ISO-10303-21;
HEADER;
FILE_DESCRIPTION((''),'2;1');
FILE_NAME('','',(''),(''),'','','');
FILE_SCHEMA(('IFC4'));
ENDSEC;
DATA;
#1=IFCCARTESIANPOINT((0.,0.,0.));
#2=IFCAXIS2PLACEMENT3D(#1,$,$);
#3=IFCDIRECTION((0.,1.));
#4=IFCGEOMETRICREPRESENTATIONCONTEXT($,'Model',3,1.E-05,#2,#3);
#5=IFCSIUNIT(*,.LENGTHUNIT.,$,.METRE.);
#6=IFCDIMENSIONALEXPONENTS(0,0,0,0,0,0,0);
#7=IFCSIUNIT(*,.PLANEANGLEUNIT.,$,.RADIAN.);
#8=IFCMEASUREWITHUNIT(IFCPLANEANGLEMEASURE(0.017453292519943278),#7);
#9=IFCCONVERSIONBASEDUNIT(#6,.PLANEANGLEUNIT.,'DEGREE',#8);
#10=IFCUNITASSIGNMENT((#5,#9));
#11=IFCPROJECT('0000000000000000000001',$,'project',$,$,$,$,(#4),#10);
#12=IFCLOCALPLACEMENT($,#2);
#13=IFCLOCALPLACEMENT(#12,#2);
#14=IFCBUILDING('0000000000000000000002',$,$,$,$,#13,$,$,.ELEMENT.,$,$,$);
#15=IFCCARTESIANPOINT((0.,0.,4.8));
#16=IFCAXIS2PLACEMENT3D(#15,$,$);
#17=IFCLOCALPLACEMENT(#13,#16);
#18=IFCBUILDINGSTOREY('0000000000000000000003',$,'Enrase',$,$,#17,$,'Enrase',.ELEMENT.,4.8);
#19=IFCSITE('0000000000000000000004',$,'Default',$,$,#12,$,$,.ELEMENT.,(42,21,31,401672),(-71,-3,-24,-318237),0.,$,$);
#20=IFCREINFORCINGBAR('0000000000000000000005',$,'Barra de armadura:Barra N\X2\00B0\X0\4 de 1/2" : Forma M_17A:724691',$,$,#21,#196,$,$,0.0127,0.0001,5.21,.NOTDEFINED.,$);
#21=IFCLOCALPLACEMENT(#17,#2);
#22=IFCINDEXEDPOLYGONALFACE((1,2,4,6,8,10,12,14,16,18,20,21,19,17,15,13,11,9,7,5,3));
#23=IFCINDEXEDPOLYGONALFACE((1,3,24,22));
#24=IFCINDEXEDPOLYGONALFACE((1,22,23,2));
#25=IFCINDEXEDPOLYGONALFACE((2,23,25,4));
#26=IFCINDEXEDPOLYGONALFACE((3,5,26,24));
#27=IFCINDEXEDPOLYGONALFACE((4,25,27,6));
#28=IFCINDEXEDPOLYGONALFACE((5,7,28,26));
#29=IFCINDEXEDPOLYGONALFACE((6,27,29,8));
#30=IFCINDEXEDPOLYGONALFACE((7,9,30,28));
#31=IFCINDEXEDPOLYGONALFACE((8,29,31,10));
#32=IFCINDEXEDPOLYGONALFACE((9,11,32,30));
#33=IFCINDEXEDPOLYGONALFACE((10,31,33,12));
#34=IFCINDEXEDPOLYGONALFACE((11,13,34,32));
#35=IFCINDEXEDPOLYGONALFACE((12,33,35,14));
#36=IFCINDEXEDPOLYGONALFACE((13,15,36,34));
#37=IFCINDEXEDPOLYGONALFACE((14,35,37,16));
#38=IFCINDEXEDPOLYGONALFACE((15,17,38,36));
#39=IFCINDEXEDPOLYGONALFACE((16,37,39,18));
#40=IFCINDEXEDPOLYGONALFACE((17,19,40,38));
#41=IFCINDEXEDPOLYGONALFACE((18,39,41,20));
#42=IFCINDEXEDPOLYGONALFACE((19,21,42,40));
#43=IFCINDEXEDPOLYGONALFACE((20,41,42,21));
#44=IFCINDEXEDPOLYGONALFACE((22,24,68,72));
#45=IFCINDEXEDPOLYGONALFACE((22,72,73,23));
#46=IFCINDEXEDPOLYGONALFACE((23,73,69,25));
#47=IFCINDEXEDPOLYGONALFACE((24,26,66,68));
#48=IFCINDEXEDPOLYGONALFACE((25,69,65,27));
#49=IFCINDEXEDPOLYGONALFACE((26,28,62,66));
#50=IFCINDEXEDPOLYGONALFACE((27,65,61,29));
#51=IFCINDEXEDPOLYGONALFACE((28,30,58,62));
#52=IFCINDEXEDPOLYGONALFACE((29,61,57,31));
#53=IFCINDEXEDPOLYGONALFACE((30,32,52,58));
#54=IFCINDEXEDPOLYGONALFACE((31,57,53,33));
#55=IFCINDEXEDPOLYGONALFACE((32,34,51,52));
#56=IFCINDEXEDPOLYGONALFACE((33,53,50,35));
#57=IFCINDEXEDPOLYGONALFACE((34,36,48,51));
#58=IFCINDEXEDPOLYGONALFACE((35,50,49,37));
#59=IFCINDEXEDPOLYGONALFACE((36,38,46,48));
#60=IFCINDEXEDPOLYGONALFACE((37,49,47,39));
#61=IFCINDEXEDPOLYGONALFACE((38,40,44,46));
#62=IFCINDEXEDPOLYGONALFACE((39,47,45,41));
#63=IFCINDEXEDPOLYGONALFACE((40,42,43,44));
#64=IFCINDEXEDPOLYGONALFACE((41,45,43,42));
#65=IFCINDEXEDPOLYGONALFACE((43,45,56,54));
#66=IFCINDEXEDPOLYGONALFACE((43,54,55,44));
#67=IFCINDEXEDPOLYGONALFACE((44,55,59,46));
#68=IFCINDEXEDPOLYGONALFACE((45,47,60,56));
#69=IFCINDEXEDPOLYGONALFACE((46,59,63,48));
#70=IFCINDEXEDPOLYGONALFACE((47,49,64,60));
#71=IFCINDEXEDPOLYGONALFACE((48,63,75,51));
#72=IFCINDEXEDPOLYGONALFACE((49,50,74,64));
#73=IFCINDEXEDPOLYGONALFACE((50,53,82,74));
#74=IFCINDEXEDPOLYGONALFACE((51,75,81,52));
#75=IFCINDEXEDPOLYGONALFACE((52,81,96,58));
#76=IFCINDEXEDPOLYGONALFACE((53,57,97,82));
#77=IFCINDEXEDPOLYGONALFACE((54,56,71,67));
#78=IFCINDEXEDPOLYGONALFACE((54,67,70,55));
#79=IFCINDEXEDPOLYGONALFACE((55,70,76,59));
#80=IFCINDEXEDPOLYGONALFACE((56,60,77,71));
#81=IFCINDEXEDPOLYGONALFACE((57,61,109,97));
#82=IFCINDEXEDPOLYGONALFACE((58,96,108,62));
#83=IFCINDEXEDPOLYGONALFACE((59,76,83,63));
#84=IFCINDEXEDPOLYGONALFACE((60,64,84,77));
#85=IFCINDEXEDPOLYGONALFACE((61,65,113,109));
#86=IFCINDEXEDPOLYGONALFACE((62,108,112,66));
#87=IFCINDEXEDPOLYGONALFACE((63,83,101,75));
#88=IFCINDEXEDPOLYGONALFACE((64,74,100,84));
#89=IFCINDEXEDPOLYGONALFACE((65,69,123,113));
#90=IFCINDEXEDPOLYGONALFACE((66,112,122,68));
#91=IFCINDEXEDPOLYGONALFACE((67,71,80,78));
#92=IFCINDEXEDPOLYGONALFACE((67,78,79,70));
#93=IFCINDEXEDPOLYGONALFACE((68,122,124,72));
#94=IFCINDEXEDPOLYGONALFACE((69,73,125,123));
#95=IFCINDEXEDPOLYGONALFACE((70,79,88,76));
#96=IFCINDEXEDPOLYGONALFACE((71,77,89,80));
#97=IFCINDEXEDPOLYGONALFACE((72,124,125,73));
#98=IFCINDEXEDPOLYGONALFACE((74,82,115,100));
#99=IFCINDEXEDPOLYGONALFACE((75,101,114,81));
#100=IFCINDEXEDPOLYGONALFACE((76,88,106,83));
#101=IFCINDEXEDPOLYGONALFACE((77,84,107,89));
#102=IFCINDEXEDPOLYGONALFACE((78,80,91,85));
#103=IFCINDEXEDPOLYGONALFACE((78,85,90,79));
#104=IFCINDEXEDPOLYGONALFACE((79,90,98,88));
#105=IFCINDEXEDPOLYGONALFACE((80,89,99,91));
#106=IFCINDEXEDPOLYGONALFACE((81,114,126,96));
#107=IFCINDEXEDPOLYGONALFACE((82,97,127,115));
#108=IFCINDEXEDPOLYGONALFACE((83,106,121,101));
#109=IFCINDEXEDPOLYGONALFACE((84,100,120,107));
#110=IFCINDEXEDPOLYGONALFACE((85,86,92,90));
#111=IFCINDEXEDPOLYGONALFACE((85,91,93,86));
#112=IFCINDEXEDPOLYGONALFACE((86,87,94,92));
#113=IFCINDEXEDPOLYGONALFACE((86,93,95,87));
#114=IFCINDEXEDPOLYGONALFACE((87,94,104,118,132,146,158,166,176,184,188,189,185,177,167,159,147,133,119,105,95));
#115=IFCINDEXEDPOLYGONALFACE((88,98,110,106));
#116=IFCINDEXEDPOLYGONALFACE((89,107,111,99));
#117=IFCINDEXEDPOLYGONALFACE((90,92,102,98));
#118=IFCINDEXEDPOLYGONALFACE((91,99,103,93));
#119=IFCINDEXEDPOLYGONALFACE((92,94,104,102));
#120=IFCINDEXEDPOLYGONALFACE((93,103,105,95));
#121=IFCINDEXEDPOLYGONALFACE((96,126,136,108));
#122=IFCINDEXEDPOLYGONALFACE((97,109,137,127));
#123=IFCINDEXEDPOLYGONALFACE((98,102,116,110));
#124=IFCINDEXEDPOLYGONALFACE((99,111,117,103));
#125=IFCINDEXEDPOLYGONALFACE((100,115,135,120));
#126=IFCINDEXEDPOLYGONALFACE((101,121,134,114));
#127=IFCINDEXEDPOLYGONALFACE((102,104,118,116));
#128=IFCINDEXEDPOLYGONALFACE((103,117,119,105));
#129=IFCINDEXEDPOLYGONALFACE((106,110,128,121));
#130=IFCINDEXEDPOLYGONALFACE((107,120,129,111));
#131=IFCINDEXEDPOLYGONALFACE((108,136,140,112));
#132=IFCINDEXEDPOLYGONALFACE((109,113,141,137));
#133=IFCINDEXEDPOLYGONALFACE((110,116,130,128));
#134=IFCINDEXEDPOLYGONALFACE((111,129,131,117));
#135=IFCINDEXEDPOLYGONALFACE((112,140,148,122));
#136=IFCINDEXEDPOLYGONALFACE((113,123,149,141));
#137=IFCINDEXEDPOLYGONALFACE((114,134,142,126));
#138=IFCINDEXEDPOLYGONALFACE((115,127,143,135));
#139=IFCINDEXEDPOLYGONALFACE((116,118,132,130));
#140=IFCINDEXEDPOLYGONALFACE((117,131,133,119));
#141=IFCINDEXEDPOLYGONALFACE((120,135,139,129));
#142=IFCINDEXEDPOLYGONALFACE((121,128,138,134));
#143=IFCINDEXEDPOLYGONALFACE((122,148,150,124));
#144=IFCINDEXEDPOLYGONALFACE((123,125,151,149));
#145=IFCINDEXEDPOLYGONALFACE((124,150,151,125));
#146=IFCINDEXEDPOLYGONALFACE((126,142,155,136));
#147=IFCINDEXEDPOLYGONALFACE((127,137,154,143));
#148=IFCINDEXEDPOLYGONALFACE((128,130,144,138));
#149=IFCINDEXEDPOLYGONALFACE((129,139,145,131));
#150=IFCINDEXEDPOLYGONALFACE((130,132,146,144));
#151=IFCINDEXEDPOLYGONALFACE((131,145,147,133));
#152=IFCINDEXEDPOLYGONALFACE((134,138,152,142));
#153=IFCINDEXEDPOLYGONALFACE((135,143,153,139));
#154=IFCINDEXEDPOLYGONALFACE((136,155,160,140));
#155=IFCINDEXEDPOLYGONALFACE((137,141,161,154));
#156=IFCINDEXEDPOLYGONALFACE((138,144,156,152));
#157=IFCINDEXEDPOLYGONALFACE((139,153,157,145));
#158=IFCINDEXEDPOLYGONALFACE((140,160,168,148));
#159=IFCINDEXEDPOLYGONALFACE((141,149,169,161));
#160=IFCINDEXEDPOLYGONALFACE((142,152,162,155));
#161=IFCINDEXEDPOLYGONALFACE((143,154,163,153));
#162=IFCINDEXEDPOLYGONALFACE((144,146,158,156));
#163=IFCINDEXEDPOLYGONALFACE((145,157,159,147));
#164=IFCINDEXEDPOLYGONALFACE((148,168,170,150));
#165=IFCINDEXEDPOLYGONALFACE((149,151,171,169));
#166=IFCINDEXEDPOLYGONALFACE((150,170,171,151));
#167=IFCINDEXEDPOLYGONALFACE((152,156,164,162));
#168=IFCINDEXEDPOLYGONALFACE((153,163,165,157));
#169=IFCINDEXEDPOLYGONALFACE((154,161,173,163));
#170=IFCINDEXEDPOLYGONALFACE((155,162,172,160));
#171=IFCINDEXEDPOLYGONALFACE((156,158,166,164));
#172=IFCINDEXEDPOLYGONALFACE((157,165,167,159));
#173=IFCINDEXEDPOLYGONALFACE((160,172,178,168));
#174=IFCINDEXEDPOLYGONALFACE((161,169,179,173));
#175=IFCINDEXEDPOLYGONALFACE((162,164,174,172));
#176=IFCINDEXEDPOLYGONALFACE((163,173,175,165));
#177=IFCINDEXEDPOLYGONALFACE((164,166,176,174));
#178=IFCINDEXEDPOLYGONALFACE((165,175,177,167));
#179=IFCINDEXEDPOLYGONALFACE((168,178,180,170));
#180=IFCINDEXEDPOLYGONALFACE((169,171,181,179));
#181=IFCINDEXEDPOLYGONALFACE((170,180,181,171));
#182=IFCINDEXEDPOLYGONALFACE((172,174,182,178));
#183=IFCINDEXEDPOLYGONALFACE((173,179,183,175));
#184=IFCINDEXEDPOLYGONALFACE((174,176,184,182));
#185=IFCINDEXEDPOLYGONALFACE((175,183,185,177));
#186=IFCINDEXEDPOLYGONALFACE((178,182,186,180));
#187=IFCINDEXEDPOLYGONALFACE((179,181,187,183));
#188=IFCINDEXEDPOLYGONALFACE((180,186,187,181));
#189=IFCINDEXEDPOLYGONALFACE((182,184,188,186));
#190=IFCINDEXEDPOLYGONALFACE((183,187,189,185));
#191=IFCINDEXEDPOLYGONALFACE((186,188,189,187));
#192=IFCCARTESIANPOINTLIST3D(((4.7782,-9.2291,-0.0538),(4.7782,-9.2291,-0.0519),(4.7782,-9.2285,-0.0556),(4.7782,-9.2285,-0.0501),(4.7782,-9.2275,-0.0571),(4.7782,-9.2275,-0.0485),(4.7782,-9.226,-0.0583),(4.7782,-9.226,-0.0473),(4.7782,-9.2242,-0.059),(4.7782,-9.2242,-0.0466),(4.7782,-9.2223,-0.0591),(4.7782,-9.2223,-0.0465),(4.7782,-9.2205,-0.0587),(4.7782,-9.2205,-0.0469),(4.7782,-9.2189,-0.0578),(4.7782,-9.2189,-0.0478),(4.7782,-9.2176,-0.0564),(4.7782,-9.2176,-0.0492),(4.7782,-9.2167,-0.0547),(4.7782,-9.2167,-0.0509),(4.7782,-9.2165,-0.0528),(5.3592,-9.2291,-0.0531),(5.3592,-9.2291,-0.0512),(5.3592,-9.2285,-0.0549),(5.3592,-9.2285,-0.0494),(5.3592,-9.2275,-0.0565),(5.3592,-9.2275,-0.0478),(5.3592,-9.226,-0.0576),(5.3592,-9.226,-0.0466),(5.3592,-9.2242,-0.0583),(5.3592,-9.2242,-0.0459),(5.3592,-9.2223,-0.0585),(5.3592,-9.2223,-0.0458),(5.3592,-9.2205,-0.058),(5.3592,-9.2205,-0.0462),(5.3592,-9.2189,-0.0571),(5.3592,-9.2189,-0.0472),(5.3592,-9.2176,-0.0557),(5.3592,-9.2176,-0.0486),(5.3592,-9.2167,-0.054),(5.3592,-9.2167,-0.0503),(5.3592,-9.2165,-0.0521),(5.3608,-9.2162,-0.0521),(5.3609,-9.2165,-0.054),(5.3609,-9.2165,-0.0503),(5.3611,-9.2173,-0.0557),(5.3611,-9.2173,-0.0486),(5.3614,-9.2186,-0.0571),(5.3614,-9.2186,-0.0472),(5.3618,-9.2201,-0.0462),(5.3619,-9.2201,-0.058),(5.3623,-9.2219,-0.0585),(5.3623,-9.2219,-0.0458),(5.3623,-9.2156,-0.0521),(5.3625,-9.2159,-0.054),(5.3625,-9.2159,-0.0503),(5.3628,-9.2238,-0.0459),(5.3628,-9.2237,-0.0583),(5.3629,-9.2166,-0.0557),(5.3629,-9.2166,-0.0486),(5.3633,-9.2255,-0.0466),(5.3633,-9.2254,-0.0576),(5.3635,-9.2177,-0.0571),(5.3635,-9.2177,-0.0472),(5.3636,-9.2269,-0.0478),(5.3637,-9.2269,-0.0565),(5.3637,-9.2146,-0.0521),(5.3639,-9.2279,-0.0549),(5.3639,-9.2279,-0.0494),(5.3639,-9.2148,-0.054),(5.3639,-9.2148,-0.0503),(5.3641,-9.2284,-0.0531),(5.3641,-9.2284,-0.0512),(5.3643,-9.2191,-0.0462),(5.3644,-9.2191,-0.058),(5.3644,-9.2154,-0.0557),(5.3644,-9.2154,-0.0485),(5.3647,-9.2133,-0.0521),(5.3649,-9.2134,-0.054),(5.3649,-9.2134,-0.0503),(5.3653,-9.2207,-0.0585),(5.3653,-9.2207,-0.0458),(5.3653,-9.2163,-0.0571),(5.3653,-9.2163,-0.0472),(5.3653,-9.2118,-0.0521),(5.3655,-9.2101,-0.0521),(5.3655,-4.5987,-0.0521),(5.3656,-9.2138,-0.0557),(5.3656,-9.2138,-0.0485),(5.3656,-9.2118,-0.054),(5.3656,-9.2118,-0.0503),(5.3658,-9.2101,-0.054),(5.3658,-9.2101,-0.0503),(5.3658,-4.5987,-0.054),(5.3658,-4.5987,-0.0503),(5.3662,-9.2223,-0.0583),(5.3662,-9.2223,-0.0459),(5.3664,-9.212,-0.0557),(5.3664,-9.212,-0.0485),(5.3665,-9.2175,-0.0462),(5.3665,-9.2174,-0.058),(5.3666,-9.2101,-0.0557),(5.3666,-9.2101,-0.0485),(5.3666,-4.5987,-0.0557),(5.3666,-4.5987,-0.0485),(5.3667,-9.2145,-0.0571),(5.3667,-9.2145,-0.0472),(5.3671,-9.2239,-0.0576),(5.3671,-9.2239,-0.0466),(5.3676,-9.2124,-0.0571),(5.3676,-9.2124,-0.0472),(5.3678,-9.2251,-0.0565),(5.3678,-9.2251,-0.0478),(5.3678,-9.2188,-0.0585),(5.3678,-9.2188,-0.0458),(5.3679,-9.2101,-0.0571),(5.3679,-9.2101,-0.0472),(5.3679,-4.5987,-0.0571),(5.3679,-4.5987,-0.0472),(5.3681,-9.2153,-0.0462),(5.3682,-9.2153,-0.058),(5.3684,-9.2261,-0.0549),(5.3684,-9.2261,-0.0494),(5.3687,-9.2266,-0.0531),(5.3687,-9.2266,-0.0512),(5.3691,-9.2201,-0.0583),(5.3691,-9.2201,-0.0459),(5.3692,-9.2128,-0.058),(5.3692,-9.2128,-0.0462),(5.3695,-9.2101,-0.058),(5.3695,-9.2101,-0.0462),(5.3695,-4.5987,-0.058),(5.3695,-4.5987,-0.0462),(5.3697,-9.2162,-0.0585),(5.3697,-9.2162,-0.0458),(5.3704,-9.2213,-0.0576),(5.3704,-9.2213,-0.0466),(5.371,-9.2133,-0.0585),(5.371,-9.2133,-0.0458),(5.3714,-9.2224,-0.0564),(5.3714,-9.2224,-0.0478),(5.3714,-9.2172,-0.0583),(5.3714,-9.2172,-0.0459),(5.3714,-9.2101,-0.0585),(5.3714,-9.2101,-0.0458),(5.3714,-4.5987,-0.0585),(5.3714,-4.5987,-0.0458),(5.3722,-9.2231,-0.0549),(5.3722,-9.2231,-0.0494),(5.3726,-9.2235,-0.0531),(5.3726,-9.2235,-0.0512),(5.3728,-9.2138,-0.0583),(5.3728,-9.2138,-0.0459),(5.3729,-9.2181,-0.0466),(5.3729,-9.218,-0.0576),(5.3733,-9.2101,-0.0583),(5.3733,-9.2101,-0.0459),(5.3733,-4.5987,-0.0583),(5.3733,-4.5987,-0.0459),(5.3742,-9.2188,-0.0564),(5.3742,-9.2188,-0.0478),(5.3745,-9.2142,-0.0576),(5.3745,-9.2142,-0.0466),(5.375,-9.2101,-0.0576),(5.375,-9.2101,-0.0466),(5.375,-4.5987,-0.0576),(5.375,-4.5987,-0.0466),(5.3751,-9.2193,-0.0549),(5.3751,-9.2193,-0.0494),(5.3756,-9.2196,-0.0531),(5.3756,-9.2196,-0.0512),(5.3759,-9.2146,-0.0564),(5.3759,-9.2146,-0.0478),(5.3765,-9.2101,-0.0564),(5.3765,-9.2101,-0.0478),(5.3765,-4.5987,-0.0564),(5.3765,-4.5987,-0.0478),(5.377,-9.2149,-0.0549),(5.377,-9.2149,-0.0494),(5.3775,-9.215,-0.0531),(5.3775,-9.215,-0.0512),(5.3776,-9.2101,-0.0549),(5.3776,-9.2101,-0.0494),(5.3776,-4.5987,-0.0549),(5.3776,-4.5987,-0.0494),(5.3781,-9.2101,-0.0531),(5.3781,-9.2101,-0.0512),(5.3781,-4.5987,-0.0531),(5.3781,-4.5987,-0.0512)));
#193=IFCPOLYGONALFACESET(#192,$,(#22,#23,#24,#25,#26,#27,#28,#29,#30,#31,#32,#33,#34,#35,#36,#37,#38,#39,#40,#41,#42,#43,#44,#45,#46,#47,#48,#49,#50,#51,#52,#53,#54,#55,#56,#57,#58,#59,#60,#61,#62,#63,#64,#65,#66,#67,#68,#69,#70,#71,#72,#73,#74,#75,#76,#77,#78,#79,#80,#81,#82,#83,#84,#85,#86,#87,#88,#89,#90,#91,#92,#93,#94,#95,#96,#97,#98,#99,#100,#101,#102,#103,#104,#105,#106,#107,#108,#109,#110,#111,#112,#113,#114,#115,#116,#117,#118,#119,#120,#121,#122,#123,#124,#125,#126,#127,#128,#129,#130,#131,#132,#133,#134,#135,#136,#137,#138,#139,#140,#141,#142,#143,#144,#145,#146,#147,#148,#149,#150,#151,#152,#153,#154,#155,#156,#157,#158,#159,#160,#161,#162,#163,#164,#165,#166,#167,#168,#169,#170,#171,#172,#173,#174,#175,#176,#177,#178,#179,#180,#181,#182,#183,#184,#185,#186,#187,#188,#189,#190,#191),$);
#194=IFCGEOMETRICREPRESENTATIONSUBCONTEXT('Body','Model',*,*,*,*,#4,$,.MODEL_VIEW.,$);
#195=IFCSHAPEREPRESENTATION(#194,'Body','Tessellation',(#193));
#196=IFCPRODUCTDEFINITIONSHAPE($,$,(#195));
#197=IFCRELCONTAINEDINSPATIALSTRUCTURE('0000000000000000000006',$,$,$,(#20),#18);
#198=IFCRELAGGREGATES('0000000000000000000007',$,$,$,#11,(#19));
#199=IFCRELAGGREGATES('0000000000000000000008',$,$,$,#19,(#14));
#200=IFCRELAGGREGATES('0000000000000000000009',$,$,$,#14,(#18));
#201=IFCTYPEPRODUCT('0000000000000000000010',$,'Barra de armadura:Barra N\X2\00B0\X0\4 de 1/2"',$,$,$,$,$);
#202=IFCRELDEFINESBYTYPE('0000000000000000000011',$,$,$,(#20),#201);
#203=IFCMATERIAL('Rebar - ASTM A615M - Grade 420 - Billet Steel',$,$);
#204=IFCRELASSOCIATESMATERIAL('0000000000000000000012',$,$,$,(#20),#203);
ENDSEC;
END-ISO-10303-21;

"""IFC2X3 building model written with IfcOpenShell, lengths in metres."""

from ifc_helpers import new_model, entity, si_unit, converted_unit, direction, frame, origin, place, context, subcontext, project, spatial, material, type_object, element, save


model = new_model("IFC2X3")

# Units and contexts
model_context = context("Model", 3, precision=1e-05, world=origin(), true_north=direction((0.0, 1.0)))
body_context = subcontext(model_context, "Body", "Model", "MODEL_VIEW")
ifc_project = project(units=[si_unit("LENGTHUNIT", "METRE"), converted_unit("PLANEANGLEUNIT", "DEGREE", entity("IfcPlaneAngleMeasure", 0.017453292519943278), si_unit("PLANEANGLEUNIT", "RADIAN"), dimensions=[0, 0, 0, 0, 0, 0, 0])], contexts=[model_context])

# Site, building, storey
site_placement = place(None, origin())
site = spatial("IfcSite", under=ifc_project, at=site_placement, Name="Default", CompositionType="ELEMENT", RefLatitude=(42, 21, 31, 401672), RefLongitude=(-71, -3, -24, -318237), RefElevation=0.0)
building_placement = place(site_placement, origin())
building = spatial("IfcBuilding", under=site, at=building_placement, CompositionType="ELEMENT")
storey_placement = place(building_placement, frame((0.0, 0.0, 4.8)))
storey = spatial("IfcBuildingStorey", under=building, at=storey_placement, Name="Enrase", LongName="Enrase", CompositionType="ELEMENT", Elevation=4.8)

# Reinforcing bar
ifc_material = material(Name="Rebar - ASTM A615M - Grade 420 - Billet Steel")
type_product_1 = type_object("IfcTypeProduct", Name="Barra de armadura:Barra N°4 de 1/2\"")
reinforcing_bar_1_placement = place(storey_placement, origin())
element("IfcReinforcingBar", 1, at=reinforcing_bar_1_placement, inside=storey, type_object=type_product_1, material=ifc_material, Name="Barra de armadura:Barra N°4 de 1/2\" : Forma M_17A:724691", BarLength=5.21, BarRole="NOTDEFINED", CrossSectionArea=0.0001, NominalDiameter=0.0127, context=body_context, shape_type="AdvancedSweptSolid", body=[
    entity("IfcSweptDiskSolid", entity("IfcCompositeCurve", [entity("IfcCompositeCurveSegment", "CONTINUOUS", True, entity("IfcPolyline", [entity("IfcCartesianPoint", [5.3719, -4.5987, -0.0521]), entity("IfcCartesianPoint", [5.3719, -9.2101, -0.0521])])), entity("IfcCompositeCurveSegment", "CONTINUOUS", True, entity("IfcTrimmedCurve", entity("IfcCircle", entity("IfcAxis2Placement3D", entity("IfcCartesianPoint", [5.3592, -9.2101, -0.0521]), entity("IfcDirection", [0.001144, 0.0, -0.999999]), entity("IfcDirection", [0.0, -1.0, 0.0])), 0.0127), [entity("IfcParameterValue", 270.0)], [entity("IfcParameterValue", 360.0)], True, "PARAMETER")), entity("IfcCompositeCurveSegment", "CONTINUOUS", True, entity("IfcPolyline", [entity("IfcCartesianPoint", [5.3592, -9.2228, -0.0521]), entity("IfcCartesianPoint", [4.7782, -9.2228, -0.0528])]))], False), 0.0063, None, 0.0, 92.0),
])

save(model, "model.ifc")
